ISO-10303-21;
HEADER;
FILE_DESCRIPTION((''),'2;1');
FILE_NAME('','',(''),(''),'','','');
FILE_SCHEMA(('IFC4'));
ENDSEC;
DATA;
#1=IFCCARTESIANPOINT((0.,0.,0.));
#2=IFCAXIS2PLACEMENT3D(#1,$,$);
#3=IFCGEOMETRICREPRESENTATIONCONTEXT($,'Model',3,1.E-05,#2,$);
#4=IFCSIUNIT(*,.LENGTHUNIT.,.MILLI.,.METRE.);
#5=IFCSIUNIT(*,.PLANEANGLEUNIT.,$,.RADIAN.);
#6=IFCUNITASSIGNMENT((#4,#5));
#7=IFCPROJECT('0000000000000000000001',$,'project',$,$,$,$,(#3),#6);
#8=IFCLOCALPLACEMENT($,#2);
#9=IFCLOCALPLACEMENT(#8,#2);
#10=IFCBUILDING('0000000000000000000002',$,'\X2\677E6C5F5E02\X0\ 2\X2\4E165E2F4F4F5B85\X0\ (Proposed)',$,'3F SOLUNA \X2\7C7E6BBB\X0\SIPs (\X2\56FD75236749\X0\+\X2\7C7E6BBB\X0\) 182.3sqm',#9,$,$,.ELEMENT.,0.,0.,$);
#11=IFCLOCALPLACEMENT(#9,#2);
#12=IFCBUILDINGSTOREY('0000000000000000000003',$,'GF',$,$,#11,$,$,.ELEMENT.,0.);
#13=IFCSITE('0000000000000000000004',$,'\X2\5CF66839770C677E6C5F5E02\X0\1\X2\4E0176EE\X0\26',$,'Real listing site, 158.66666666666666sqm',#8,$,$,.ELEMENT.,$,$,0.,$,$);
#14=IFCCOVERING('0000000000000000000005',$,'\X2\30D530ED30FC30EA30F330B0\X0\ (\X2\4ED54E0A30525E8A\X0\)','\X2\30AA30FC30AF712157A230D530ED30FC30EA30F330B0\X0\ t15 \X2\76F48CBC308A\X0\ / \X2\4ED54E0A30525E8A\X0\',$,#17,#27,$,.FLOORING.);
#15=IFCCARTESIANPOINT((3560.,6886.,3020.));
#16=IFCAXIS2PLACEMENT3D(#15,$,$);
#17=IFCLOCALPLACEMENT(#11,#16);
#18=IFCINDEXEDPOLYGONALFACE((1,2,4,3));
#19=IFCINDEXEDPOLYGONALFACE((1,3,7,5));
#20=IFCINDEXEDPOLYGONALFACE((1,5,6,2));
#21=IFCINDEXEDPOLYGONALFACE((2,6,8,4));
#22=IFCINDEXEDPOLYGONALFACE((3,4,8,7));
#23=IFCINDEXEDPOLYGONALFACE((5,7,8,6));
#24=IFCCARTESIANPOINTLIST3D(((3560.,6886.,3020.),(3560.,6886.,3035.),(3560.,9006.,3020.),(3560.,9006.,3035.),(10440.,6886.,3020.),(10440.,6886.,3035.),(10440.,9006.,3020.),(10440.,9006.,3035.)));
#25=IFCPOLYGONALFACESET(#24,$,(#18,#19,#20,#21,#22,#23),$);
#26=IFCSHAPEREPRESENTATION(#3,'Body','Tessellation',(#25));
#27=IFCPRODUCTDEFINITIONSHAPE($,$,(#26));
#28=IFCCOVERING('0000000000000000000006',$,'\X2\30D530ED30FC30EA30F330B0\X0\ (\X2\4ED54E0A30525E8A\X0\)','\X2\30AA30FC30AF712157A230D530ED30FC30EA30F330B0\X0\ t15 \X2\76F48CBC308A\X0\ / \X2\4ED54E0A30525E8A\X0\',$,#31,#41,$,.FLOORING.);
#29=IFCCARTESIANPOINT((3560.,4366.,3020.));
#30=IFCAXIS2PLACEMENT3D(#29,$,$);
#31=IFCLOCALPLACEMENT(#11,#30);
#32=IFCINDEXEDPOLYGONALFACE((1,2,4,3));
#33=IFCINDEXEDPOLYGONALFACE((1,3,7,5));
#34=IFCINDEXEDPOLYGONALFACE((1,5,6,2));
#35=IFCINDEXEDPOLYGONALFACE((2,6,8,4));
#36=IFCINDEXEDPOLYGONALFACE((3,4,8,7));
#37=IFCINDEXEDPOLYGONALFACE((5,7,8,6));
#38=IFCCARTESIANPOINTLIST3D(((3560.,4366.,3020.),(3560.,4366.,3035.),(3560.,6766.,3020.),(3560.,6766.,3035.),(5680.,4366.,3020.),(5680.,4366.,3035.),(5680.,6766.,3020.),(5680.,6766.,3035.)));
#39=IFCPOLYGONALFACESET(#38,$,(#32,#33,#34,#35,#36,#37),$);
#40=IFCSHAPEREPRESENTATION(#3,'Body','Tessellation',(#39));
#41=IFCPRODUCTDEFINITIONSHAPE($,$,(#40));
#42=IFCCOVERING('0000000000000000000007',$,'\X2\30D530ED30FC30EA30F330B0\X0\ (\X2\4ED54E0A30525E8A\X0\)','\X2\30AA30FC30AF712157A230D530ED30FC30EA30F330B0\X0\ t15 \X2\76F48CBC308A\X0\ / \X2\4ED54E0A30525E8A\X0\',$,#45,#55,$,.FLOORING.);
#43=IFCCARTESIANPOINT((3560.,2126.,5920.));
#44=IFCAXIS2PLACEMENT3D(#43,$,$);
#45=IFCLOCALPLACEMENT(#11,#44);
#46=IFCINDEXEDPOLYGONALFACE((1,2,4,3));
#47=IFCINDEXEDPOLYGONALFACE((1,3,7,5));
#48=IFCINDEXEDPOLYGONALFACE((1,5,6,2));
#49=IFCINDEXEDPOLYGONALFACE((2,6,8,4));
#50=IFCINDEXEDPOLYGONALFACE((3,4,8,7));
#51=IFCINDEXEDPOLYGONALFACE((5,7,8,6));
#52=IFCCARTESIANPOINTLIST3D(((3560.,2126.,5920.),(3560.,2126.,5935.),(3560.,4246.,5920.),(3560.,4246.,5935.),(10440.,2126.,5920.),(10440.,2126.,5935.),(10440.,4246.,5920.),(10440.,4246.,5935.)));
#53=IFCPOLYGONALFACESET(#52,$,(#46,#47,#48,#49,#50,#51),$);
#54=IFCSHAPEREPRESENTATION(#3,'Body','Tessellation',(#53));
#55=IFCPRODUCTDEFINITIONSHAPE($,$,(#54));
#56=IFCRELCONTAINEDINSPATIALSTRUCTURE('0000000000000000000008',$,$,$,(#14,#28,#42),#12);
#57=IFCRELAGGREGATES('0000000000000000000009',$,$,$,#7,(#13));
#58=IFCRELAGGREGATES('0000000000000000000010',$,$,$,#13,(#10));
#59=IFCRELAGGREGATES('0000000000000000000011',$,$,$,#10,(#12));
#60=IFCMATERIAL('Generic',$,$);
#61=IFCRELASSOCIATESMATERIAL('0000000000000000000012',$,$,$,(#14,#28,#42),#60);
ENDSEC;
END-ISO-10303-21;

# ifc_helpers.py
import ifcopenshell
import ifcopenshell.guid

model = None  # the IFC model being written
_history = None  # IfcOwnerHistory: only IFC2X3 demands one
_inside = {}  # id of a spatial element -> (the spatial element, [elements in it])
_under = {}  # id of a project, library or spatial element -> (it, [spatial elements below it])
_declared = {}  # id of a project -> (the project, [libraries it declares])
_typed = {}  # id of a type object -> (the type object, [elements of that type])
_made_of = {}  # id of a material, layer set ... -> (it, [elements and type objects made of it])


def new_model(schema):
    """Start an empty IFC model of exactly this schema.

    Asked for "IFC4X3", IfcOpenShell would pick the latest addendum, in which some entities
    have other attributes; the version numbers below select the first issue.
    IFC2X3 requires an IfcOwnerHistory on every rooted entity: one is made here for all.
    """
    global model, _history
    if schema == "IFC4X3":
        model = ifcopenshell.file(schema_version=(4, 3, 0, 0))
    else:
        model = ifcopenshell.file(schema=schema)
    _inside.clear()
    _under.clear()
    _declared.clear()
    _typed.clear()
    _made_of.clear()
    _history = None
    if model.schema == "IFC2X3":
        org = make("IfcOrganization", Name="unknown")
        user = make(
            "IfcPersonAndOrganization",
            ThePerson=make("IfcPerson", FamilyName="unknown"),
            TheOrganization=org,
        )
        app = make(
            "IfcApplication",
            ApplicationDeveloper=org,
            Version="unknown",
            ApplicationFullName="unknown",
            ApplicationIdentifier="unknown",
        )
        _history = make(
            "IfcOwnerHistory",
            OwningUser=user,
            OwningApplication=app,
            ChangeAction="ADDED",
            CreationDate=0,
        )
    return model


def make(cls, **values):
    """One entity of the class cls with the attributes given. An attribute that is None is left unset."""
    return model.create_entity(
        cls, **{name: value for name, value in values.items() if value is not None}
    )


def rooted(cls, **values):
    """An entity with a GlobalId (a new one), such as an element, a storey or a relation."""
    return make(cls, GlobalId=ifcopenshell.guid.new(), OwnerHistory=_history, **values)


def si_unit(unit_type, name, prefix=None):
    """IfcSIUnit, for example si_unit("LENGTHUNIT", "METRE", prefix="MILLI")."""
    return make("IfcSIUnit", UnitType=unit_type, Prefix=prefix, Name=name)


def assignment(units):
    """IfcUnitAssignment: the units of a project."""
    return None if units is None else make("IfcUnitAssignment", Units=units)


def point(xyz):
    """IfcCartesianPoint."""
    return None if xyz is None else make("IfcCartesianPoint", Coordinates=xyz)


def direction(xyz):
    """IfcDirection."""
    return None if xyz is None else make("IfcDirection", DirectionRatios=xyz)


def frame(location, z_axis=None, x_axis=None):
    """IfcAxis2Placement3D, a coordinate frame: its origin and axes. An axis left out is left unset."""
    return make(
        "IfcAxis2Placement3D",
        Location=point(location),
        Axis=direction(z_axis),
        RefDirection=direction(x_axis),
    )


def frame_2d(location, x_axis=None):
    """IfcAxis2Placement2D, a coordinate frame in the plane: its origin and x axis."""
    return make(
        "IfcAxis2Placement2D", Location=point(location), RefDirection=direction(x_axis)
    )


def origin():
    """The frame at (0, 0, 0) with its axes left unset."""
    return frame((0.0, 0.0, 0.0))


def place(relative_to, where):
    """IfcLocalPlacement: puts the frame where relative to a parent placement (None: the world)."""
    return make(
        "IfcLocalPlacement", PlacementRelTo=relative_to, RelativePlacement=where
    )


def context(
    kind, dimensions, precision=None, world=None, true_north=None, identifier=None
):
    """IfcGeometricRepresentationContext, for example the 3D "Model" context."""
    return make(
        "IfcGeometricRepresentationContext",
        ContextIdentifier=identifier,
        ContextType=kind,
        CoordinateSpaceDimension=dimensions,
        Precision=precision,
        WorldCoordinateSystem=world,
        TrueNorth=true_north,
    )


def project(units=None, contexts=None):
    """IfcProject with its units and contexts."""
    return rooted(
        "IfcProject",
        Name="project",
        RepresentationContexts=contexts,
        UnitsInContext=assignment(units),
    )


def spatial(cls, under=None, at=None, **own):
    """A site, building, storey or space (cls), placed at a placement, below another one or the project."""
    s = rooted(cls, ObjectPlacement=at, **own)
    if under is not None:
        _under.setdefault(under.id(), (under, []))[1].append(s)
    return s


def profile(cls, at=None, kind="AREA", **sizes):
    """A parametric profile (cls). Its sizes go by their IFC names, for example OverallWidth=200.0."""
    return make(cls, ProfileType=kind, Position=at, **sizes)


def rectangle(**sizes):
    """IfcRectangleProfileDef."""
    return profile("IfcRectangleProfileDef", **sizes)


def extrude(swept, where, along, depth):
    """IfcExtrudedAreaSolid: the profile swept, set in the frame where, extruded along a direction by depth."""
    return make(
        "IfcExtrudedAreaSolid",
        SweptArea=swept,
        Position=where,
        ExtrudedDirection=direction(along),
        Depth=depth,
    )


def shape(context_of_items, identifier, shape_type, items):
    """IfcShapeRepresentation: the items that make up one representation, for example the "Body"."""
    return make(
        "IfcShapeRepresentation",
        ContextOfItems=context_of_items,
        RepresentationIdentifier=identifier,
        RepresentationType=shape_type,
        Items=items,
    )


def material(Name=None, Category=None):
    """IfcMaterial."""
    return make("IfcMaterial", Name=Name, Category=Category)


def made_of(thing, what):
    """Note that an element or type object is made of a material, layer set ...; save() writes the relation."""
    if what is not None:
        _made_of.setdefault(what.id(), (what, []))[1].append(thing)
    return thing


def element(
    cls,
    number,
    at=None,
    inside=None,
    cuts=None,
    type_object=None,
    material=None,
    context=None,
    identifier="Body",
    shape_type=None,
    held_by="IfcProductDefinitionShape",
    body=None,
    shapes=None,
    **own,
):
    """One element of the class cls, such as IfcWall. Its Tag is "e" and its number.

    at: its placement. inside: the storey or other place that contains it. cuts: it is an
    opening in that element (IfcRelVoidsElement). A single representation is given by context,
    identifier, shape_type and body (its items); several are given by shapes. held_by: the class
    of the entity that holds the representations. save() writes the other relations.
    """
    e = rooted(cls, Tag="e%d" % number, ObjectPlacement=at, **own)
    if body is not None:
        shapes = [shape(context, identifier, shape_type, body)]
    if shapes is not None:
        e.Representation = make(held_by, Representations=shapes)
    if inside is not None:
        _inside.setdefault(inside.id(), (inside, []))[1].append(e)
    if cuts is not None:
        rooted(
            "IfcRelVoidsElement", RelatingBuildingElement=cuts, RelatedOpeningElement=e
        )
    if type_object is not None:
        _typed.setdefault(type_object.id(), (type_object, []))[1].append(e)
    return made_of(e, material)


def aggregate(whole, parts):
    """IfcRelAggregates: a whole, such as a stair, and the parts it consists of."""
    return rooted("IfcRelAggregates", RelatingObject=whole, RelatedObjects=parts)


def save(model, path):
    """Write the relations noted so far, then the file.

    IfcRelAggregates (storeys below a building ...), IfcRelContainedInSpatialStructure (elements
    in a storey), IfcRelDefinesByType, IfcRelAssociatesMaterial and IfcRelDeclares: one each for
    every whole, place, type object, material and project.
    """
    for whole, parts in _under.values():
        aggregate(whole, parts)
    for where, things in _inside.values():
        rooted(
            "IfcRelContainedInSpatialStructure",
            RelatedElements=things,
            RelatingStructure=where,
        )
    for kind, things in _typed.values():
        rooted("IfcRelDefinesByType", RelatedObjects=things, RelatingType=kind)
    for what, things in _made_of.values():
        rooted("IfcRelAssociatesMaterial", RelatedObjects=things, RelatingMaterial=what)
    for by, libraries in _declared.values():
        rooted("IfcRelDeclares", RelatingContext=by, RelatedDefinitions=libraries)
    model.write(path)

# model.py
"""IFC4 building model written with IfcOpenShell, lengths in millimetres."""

from ifc_helpers import new_model, si_unit, frame, frame_2d, origin, place, context, project, spatial, rectangle, extrude, material, element, save


model = new_model("IFC4")

# Units and contexts
model_context = context("Model", 3, precision=1e-05, world=origin())
ifc_project = project(units=[si_unit("LENGTHUNIT", "METRE", prefix="MILLI"), si_unit("PLANEANGLEUNIT", "RADIAN")], contexts=[model_context])

# Site, building, storey
site_placement = place(None, origin())
site = spatial("IfcSite", under=ifc_project, at=site_placement, Name="島根県松江市1丁目26", ObjectType="Real listing site, 158.66666666666666sqm", CompositionType="ELEMENT", RefElevation=0.0)
building_placement = place(site_placement, origin())
building = spatial("IfcBuilding", under=site, at=building_placement, Name="松江市 2世帯住宅 (Proposed)", ObjectType="3F SOLUNA 籾殻SIPs (国産杉+籾殻) 182.3sqm", CompositionType="ELEMENT", ElevationOfRefHeight=0.0, ElevationOfTerrain=0.0)
storey_placement = place(building_placement, origin())
storey = spatial("IfcBuildingStorey", under=building, at=storey_placement, Name="GF", CompositionType="ELEMENT", Elevation=0.0)

# Shared definitions
ifc_material_1 = material(Name="Generic")

# Coverings
covering_1_placement = place(storey_placement, frame((3560.0, 6886.0, 3020.0)))
element("IfcCovering", 1, at=covering_1_placement, inside=storey, material=ifc_material_1, Name="フローリング (仕上げ床)", Description="オーク無垢フローリング t15 直貼り / 仕上げ床", PredefinedType="FLOORING", context=model_context, shape_type="SweptSolid", body=[
    extrude(rectangle(XDim=6880.0, YDim=2120.0, at=frame_2d((3440.0, 1060.0))), frame((3560.0, 6886.0, 3020.0)), (0.0, 0.0, 1.0), 15.0),
])
covering_2_placement = place(storey_placement, frame((3560.0, 4366.0, 3020.0)))
element("IfcCovering", 2, at=covering_2_placement, inside=storey, material=ifc_material_1, Name="フローリング (仕上げ床)", Description="オーク無垢フローリング t15 直貼り / 仕上げ床", PredefinedType="FLOORING", context=model_context, shape_type="SweptSolid", body=[
    extrude(rectangle(XDim=2120.0, YDim=2400.0, at=frame_2d((1060.0, 1200.0))), frame((3560.0, 4366.0, 3020.0)), (0.0, 0.0, 1.0), 15.0),
])
covering_3_placement = place(storey_placement, frame((3560.0, 2126.0, 5920.0)))
element("IfcCovering", 3, at=covering_3_placement, inside=storey, material=ifc_material_1, Name="フローリング (仕上げ床)", Description="オーク無垢フローリング t15 直貼り / 仕上げ床", PredefinedType="FLOORING", context=model_context, shape_type="SweptSolid", body=[
    extrude(rectangle(XDim=6880.0, YDim=2120.0, at=frame_2d((3440.0, 1060.0))), frame((3560.0, 2126.0, 5920.0)), (0.0, 0.0, 1.0), 15.0),
])

save(model, "model.ifc")
